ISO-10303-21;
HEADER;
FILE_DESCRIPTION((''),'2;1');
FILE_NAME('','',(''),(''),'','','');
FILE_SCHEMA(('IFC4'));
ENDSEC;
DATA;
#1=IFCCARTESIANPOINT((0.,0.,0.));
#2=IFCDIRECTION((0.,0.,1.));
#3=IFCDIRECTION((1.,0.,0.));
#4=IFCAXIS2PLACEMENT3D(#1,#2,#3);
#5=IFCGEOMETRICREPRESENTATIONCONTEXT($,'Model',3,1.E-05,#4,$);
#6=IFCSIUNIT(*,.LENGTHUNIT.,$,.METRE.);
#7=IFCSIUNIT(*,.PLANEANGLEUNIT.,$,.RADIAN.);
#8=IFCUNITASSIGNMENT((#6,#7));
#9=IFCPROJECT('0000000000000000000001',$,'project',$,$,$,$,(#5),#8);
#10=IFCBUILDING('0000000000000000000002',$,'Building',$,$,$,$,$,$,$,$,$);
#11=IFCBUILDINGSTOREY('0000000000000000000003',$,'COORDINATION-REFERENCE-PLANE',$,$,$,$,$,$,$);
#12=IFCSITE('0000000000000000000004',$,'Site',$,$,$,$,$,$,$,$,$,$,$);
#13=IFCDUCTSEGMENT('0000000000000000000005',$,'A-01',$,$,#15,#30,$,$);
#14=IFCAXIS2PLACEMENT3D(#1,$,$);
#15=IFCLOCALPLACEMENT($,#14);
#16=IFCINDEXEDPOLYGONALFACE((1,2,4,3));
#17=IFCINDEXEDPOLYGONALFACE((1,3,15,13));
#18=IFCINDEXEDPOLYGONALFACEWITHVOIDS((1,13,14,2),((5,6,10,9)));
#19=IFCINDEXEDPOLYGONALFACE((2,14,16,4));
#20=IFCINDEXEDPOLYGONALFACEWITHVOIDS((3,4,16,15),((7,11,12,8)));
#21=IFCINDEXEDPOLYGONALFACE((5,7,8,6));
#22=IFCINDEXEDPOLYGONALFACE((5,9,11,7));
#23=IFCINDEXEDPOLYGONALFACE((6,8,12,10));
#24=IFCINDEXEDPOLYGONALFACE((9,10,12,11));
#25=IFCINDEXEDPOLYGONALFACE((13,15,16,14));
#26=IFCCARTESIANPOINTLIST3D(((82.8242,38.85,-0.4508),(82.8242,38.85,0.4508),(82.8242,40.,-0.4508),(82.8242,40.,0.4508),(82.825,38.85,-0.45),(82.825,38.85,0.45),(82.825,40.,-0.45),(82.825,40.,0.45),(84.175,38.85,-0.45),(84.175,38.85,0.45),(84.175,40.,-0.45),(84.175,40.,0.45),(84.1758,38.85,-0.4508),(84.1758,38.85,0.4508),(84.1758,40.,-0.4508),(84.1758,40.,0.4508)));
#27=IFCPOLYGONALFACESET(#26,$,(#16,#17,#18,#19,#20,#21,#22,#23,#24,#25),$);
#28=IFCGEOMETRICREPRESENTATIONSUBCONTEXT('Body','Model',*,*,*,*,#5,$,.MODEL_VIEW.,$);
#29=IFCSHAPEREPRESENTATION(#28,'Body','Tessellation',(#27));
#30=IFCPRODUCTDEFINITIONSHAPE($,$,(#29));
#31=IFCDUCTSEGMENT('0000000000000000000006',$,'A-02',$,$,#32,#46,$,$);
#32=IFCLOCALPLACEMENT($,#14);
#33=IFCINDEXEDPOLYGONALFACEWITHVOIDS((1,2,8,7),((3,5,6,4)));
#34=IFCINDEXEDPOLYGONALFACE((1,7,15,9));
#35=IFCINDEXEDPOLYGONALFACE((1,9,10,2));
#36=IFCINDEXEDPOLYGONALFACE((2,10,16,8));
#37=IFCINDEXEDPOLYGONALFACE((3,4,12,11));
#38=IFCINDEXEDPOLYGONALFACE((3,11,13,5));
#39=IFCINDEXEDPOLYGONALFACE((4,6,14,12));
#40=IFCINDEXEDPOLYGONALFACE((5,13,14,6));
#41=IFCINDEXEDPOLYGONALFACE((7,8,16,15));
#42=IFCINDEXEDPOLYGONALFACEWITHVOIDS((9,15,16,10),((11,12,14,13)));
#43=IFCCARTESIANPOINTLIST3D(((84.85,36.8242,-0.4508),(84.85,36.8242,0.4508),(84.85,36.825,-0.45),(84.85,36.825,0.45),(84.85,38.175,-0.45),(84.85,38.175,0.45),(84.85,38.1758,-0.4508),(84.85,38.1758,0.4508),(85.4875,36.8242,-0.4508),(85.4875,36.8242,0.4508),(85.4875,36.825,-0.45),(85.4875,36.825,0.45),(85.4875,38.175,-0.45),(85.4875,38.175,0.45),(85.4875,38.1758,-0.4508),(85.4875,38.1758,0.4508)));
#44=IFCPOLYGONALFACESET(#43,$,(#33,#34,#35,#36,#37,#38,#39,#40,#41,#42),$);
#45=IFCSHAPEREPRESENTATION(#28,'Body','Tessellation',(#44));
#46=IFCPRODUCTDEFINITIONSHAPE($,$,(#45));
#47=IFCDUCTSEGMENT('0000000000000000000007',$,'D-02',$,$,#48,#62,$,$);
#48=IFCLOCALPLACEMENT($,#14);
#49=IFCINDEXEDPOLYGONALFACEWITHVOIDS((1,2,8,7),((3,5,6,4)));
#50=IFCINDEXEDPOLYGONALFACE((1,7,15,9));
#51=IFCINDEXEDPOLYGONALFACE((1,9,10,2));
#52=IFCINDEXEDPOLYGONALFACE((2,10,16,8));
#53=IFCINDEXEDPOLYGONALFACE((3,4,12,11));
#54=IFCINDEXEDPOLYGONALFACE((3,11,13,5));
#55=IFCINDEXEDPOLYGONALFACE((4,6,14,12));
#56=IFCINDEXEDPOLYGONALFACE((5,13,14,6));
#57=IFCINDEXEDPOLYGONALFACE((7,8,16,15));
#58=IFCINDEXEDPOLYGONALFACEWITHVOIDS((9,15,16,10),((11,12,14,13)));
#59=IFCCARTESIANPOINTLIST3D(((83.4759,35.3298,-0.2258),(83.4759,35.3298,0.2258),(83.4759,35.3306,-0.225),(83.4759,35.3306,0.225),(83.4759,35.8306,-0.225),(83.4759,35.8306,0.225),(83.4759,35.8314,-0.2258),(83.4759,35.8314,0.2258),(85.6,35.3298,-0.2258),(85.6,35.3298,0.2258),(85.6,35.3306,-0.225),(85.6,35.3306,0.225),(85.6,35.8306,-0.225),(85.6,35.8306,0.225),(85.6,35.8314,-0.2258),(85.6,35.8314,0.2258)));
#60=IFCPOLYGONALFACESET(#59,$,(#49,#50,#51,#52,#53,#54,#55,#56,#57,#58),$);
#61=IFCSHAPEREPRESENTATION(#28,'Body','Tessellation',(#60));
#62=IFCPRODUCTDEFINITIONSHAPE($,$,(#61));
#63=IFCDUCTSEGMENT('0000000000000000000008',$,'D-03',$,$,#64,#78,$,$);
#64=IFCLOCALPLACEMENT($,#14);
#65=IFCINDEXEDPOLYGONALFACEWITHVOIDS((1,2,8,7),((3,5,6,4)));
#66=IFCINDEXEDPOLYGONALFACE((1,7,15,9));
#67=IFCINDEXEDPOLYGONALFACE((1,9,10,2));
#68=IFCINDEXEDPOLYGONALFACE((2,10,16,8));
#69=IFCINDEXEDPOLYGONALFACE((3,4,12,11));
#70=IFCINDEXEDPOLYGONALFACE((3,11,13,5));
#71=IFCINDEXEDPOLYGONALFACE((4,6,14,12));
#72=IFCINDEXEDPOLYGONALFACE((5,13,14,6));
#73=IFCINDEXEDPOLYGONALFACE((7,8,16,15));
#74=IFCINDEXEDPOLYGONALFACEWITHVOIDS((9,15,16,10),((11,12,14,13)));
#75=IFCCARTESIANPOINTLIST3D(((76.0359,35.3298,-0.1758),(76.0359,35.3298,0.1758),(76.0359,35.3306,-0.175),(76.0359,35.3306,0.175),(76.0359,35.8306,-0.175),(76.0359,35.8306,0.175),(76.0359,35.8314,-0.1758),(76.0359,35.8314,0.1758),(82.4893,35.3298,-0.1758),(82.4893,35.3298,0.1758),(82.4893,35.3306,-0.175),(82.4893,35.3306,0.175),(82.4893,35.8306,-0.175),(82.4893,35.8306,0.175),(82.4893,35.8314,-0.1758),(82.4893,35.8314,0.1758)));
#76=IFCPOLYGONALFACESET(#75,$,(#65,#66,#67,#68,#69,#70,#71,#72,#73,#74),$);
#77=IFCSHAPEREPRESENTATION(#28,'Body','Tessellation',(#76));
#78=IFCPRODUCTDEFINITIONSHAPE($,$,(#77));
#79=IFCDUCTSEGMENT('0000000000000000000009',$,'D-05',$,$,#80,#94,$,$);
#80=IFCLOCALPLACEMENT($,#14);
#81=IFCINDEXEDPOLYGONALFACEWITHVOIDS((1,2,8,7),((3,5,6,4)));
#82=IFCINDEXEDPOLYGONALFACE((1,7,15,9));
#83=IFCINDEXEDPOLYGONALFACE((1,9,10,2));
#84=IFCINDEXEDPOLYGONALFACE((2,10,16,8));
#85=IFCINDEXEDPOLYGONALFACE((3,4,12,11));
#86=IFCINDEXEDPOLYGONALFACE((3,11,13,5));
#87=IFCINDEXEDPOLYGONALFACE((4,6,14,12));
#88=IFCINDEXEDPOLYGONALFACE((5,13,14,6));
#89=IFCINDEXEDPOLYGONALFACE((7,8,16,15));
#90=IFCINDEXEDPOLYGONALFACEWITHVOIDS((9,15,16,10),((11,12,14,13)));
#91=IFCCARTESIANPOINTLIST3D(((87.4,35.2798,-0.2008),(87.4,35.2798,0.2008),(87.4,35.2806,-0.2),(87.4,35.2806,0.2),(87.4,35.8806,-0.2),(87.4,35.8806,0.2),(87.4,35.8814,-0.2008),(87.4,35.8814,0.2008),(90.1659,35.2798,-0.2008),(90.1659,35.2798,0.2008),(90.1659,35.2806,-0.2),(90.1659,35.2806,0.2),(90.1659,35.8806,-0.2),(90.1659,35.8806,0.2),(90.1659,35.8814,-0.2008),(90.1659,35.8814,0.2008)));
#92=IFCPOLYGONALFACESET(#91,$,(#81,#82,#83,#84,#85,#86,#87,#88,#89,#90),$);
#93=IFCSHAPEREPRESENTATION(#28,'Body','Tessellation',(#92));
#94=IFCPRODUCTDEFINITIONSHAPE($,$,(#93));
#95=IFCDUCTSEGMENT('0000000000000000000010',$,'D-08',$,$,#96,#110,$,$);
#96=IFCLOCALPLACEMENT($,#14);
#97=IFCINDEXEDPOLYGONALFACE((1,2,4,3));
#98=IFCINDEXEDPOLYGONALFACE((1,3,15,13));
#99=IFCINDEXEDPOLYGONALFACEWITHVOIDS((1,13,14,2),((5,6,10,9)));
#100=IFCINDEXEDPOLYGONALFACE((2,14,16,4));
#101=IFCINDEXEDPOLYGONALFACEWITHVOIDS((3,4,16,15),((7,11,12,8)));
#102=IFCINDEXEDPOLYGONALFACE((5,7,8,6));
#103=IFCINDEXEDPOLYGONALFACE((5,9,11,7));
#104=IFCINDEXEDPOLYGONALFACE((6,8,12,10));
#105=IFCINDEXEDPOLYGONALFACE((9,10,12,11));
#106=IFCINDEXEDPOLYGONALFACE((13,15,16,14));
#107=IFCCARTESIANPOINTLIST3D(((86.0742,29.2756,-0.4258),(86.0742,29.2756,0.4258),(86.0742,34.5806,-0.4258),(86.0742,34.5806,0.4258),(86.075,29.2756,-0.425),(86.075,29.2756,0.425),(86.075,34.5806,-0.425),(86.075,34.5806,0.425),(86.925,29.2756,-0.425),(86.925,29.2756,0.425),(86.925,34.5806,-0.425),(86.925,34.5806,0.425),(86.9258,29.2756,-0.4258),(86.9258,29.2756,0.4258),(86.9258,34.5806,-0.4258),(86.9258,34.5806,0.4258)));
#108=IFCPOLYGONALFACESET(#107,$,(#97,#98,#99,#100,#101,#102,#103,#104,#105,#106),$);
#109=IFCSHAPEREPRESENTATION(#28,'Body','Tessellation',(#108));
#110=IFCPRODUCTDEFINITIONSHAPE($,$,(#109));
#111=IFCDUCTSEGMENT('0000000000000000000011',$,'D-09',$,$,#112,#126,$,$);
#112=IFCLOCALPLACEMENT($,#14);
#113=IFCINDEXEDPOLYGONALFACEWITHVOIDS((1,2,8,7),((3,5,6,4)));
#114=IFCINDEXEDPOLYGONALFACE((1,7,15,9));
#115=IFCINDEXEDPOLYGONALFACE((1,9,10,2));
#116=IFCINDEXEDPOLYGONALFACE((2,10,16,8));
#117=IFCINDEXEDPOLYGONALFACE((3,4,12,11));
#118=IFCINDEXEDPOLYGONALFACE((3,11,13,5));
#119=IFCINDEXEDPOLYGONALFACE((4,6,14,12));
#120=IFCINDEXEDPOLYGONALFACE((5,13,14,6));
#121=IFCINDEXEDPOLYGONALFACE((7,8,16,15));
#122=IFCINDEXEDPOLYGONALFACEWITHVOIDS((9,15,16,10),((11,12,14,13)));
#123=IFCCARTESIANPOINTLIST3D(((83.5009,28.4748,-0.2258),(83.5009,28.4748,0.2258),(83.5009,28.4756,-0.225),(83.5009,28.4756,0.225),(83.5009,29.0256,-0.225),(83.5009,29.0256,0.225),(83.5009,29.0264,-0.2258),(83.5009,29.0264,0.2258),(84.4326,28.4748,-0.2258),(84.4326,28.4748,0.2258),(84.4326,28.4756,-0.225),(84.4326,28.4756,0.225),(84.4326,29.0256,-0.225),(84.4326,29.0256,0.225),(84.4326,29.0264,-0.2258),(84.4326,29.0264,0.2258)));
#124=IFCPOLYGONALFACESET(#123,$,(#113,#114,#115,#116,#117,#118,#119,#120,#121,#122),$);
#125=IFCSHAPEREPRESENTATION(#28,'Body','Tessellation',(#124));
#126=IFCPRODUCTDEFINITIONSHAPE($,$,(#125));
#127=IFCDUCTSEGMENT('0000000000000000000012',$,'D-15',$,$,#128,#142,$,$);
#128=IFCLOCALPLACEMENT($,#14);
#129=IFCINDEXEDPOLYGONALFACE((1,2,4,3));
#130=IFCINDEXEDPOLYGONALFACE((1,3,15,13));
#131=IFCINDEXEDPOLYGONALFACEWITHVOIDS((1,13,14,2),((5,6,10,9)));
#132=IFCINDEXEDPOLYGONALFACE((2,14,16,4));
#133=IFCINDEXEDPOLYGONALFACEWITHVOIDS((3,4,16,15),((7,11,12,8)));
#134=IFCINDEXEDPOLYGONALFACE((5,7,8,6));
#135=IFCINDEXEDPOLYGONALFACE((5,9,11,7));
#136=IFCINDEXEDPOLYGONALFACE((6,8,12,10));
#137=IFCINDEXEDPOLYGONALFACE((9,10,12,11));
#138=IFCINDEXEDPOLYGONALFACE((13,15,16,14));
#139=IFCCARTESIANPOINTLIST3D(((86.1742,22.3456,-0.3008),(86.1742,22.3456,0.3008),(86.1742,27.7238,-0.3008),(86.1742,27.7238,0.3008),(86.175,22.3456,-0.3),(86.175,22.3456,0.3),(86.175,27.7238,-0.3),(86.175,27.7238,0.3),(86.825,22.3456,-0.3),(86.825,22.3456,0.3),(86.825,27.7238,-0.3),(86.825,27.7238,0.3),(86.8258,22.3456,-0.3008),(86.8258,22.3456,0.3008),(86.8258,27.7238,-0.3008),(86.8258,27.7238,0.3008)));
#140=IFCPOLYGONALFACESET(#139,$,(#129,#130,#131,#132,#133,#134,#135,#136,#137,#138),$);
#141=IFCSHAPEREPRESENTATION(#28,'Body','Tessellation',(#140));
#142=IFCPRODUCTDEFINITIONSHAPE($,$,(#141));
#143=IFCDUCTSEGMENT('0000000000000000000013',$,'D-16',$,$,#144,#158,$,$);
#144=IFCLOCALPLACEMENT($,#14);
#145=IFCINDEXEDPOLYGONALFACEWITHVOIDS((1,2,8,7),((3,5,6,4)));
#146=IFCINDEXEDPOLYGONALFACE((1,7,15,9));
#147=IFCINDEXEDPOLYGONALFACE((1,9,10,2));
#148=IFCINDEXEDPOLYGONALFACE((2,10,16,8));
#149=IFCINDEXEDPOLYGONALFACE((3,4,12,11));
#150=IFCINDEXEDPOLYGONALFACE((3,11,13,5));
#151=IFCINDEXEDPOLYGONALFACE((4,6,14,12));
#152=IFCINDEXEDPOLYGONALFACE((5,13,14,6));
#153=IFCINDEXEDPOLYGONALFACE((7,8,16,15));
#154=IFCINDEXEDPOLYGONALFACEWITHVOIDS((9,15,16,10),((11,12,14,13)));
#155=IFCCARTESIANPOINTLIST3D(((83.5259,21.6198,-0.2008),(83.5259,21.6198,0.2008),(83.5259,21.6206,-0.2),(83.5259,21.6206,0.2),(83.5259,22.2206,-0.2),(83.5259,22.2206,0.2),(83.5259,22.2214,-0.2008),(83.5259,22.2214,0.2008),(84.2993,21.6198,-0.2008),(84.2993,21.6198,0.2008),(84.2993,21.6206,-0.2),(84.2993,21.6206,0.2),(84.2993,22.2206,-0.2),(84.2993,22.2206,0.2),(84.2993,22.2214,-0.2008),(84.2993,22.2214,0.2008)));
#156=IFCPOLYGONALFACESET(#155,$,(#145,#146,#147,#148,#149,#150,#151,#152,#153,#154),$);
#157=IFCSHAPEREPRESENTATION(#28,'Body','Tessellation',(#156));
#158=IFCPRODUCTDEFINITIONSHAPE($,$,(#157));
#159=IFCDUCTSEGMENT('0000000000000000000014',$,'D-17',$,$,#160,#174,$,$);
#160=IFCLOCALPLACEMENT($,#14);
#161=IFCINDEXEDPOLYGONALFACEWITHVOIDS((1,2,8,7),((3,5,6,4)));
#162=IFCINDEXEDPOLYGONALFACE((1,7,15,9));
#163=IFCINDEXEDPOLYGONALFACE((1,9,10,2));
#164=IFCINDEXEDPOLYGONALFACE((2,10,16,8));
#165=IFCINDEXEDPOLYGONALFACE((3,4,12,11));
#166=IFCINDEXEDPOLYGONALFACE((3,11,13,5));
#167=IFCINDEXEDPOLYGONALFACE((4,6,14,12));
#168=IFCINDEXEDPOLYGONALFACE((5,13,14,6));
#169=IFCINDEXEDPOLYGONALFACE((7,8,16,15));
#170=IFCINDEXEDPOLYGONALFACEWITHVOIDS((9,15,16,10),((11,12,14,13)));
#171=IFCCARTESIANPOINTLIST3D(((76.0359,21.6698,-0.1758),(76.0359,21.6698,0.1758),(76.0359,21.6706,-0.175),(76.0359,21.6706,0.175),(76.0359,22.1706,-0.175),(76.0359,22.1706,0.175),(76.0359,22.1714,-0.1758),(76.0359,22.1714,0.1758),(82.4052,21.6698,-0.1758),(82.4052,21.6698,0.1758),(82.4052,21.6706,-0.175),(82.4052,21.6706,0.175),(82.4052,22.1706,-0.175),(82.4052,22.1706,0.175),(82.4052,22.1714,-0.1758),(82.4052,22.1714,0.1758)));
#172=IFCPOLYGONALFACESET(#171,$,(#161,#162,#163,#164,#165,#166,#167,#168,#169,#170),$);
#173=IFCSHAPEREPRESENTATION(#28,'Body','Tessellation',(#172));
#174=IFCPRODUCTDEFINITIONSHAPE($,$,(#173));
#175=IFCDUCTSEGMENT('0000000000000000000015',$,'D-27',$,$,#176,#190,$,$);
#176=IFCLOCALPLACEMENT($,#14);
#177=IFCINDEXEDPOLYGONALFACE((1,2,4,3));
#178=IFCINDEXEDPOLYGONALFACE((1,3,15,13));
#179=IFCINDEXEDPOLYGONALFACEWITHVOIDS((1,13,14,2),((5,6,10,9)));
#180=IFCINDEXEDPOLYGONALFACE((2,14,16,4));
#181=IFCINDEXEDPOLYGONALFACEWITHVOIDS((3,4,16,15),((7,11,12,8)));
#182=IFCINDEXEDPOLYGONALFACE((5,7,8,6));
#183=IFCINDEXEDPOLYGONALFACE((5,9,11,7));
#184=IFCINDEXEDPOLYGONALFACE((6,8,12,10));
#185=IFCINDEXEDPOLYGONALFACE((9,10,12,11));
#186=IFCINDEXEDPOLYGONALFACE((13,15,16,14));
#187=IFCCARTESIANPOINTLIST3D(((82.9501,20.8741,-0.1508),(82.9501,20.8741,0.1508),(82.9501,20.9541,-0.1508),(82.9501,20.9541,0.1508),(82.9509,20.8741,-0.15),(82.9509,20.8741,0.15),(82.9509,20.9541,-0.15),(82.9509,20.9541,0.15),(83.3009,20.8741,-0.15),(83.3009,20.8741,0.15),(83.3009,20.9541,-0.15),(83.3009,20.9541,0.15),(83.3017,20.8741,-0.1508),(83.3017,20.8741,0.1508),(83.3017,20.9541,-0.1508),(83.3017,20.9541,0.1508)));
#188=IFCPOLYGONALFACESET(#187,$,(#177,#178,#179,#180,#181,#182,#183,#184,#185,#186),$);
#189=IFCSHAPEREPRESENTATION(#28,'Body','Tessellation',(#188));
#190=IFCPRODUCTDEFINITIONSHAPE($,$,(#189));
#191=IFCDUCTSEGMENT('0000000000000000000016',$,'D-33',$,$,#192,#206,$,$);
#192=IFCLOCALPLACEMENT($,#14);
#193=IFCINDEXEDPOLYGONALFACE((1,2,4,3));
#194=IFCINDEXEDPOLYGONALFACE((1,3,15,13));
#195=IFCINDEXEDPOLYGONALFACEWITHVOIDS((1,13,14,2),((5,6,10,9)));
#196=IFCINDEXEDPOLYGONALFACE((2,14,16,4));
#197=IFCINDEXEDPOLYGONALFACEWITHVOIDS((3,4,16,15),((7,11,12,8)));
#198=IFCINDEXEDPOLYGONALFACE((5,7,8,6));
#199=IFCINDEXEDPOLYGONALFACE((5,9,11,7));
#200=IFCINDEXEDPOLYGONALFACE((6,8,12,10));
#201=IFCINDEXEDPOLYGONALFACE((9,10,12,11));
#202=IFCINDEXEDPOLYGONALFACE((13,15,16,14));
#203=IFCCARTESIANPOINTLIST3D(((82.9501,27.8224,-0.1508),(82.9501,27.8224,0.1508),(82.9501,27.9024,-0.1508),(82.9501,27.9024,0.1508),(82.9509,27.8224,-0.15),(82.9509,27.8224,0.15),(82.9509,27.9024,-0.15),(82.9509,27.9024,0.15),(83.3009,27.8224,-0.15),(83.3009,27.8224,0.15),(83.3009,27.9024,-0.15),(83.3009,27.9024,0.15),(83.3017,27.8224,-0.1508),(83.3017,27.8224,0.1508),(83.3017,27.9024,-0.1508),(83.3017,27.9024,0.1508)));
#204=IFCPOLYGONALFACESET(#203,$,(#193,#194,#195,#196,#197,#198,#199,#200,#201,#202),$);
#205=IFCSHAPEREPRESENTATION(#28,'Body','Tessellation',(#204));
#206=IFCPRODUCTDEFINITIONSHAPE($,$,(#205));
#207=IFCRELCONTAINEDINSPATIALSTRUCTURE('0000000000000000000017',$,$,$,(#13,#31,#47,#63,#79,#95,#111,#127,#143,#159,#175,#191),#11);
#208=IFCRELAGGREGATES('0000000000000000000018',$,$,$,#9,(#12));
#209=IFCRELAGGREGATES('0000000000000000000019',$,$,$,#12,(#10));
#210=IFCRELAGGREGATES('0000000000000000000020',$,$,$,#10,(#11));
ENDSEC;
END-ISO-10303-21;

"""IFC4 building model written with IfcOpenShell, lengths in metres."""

from ifc_helpers import new_model, si_unit, frame, origin, origin_with_axes, place, context, subcontext, project, spatial, hollow_rectangle, extrude, element, save


model = new_model("IFC4")

# Units and contexts
model_context = context("Model", 3, precision=1e-05, world=origin_with_axes())
body_context_1 = subcontext(model_context, "Body", "Model", "MODEL_VIEW")
ifc_project = project(units=[si_unit("LENGTHUNIT", "METRE"), si_unit("PLANEANGLEUNIT", "RADIAN")], contexts=[model_context])

# Site, building, storey
site = spatial("IfcSite", under=ifc_project, Name="Site")
building = spatial("IfcBuilding", under=site, Name="Building")
storey = spatial("IfcBuildingStorey", under=building, Name="COORDINATION-REFERENCE-PLANE")

# Duct segments
duct_segment_1_placement = place(None, frame((83.5, 38.85, 0.0), z_axis=(0.0, 1.0, 0.0), x_axis=(1.0, 0.0, 0.0)))
element("IfcDuctSegment", 1, at=duct_segment_1_placement, inside=storey, Name="A-01", context=body_context_1, shape_type="SweptSolid", body=[
    extrude(hollow_rectangle(XDim=1.3516, YDim=0.9016, WallThickness=0.0008), origin(), (0.0, 0.0, 1.0), 1.15),
])
duct_segment_2_placement = place(None, frame((84.85, 37.5, 0.0), z_axis=(1.0, 0.0, 0.0), x_axis=(0.0, 1.0, 0.0)))
element("IfcDuctSegment", 2, at=duct_segment_2_placement, inside=storey, Name="A-02", context=body_context_1, shape_type="SweptSolid", body=[
    extrude(hollow_rectangle(XDim=1.3516, YDim=0.9016, WallThickness=0.0008), origin(), (0.0, 0.0, 1.0), 0.6375),
])
duct_segment_3_placement = place(None, frame((83.4759, 35.5806, 0.0), z_axis=(1.0, 0.0, 0.0), x_axis=(0.0, 1.0, 0.0)))
element("IfcDuctSegment", 3, at=duct_segment_3_placement, inside=storey, Name="D-02", context=body_context_1, shape_type="SweptSolid", body=[
    extrude(hollow_rectangle(XDim=0.5016, YDim=0.4516, WallThickness=0.0008), origin(), (0.0, 0.0, 1.0), 2.1241),
])
duct_segment_4_placement = place(None, frame((76.0359, 35.5806, 0.0), z_axis=(1.0, 0.0, 0.0), x_axis=(0.0, 1.0, 0.0)))
element("IfcDuctSegment", 4, at=duct_segment_4_placement, inside=storey, Name="D-03", context=body_context_1, shape_type="SweptSolid", body=[
    extrude(hollow_rectangle(XDim=0.5016, YDim=0.3516, WallThickness=0.0008), origin(), (0.0, 0.0, 1.0), 6.4534),
])
duct_segment_5_placement = place(None, frame((87.4, 35.5806, 0.0), z_axis=(1.0, 0.0, 0.0), x_axis=(0.0, 1.0, 0.0)))
element("IfcDuctSegment", 5, at=duct_segment_5_placement, inside=storey, Name="D-05", context=body_context_1, shape_type="SweptSolid", body=[
    extrude(hollow_rectangle(XDim=0.6016, YDim=0.4016, WallThickness=0.0008), origin(), (0.0, 0.0, 1.0), 2.7659),
])
duct_segment_6_placement = place(None, frame((86.5, 29.2756, 0.0), z_axis=(0.0, 1.0, 0.0), x_axis=(1.0, 0.0, 0.0)))
element("IfcDuctSegment", 6, at=duct_segment_6_placement, inside=storey, Name="D-08", context=body_context_1, shape_type="SweptSolid", body=[
    extrude(hollow_rectangle(XDim=0.8516, YDim=0.8516, WallThickness=0.0008), origin(), (0.0, 0.0, 1.0), 5.305),
])
duct_segment_7_placement = place(None, frame((83.5009, 28.7506, 0.0), z_axis=(1.0, 0.0, 0.0), x_axis=(0.0, 1.0, 0.0)))
element("IfcDuctSegment", 7, at=duct_segment_7_placement, inside=storey, Name="D-09", context=body_context_1, shape_type="SweptSolid", body=[
    extrude(hollow_rectangle(XDim=0.5516, YDim=0.4516, WallThickness=0.0008), origin(), (0.0, 0.0, 1.0), 0.9316),
])
duct_segment_8_placement = place(None, frame((86.5, 22.3456, 0.0), z_axis=(0.0, 1.0, 0.0), x_axis=(1.0, 0.0, 0.0)))
element("IfcDuctSegment", 8, at=duct_segment_8_placement, inside=storey, Name="D-15", context=body_context_1, shape_type="SweptSolid", body=[
    extrude(hollow_rectangle(XDim=0.6516, YDim=0.6016, WallThickness=0.0008), origin(), (0.0, 0.0, 1.0), 5.3782),
])
duct_segment_9_placement = place(None, frame((83.5259, 21.9206, 0.0), z_axis=(1.0, 0.0, 0.0), x_axis=(0.0, 1.0, 0.0)))
element("IfcDuctSegment", 9, at=duct_segment_9_placement, inside=storey, Name="D-16", context=body_context_1, shape_type="SweptSolid", body=[
    extrude(hollow_rectangle(XDim=0.6016, YDim=0.4016, WallThickness=0.0008), origin(), (0.0, 0.0, 1.0), 0.7733),
])
duct_segment_10_placement = place(None, frame((76.0359, 21.9206, 0.0), z_axis=(1.0, 0.0, 0.0), x_axis=(0.0, 1.0, 0.0)))
element("IfcDuctSegment", 10, at=duct_segment_10_placement, inside=storey, Name="D-17", context=body_context_1, shape_type="SweptSolid", body=[
    extrude(hollow_rectangle(XDim=0.5016, YDim=0.3516, WallThickness=0.0008), origin(), (0.0, 0.0, 1.0), 6.3693),
])
for number, where, z_axis, x_axis, name in (
    (11, (83.1259, 20.8741, 0.0), (0.0, 1.0, 0.0), (1.0, 0.0, 0.0), "D-27"),
    (12, (83.1259, 27.8224, 0.0), (0.0, 1.0, 0.0), (1.0, 0.0, 0.0), "D-33"),
):
    element("IfcDuctSegment", number, at=place(None, frame(where, z_axis=z_axis, x_axis=x_axis)), inside=storey, Name=name, context=body_context_1, shape_type="SweptSolid", body=[
        extrude(hollow_rectangle(XDim=0.3516, YDim=0.3016, WallThickness=0.0008), origin(), (0.0, 0.0, 1.0), 0.08),
    ])

save(model, "model.ifc")
